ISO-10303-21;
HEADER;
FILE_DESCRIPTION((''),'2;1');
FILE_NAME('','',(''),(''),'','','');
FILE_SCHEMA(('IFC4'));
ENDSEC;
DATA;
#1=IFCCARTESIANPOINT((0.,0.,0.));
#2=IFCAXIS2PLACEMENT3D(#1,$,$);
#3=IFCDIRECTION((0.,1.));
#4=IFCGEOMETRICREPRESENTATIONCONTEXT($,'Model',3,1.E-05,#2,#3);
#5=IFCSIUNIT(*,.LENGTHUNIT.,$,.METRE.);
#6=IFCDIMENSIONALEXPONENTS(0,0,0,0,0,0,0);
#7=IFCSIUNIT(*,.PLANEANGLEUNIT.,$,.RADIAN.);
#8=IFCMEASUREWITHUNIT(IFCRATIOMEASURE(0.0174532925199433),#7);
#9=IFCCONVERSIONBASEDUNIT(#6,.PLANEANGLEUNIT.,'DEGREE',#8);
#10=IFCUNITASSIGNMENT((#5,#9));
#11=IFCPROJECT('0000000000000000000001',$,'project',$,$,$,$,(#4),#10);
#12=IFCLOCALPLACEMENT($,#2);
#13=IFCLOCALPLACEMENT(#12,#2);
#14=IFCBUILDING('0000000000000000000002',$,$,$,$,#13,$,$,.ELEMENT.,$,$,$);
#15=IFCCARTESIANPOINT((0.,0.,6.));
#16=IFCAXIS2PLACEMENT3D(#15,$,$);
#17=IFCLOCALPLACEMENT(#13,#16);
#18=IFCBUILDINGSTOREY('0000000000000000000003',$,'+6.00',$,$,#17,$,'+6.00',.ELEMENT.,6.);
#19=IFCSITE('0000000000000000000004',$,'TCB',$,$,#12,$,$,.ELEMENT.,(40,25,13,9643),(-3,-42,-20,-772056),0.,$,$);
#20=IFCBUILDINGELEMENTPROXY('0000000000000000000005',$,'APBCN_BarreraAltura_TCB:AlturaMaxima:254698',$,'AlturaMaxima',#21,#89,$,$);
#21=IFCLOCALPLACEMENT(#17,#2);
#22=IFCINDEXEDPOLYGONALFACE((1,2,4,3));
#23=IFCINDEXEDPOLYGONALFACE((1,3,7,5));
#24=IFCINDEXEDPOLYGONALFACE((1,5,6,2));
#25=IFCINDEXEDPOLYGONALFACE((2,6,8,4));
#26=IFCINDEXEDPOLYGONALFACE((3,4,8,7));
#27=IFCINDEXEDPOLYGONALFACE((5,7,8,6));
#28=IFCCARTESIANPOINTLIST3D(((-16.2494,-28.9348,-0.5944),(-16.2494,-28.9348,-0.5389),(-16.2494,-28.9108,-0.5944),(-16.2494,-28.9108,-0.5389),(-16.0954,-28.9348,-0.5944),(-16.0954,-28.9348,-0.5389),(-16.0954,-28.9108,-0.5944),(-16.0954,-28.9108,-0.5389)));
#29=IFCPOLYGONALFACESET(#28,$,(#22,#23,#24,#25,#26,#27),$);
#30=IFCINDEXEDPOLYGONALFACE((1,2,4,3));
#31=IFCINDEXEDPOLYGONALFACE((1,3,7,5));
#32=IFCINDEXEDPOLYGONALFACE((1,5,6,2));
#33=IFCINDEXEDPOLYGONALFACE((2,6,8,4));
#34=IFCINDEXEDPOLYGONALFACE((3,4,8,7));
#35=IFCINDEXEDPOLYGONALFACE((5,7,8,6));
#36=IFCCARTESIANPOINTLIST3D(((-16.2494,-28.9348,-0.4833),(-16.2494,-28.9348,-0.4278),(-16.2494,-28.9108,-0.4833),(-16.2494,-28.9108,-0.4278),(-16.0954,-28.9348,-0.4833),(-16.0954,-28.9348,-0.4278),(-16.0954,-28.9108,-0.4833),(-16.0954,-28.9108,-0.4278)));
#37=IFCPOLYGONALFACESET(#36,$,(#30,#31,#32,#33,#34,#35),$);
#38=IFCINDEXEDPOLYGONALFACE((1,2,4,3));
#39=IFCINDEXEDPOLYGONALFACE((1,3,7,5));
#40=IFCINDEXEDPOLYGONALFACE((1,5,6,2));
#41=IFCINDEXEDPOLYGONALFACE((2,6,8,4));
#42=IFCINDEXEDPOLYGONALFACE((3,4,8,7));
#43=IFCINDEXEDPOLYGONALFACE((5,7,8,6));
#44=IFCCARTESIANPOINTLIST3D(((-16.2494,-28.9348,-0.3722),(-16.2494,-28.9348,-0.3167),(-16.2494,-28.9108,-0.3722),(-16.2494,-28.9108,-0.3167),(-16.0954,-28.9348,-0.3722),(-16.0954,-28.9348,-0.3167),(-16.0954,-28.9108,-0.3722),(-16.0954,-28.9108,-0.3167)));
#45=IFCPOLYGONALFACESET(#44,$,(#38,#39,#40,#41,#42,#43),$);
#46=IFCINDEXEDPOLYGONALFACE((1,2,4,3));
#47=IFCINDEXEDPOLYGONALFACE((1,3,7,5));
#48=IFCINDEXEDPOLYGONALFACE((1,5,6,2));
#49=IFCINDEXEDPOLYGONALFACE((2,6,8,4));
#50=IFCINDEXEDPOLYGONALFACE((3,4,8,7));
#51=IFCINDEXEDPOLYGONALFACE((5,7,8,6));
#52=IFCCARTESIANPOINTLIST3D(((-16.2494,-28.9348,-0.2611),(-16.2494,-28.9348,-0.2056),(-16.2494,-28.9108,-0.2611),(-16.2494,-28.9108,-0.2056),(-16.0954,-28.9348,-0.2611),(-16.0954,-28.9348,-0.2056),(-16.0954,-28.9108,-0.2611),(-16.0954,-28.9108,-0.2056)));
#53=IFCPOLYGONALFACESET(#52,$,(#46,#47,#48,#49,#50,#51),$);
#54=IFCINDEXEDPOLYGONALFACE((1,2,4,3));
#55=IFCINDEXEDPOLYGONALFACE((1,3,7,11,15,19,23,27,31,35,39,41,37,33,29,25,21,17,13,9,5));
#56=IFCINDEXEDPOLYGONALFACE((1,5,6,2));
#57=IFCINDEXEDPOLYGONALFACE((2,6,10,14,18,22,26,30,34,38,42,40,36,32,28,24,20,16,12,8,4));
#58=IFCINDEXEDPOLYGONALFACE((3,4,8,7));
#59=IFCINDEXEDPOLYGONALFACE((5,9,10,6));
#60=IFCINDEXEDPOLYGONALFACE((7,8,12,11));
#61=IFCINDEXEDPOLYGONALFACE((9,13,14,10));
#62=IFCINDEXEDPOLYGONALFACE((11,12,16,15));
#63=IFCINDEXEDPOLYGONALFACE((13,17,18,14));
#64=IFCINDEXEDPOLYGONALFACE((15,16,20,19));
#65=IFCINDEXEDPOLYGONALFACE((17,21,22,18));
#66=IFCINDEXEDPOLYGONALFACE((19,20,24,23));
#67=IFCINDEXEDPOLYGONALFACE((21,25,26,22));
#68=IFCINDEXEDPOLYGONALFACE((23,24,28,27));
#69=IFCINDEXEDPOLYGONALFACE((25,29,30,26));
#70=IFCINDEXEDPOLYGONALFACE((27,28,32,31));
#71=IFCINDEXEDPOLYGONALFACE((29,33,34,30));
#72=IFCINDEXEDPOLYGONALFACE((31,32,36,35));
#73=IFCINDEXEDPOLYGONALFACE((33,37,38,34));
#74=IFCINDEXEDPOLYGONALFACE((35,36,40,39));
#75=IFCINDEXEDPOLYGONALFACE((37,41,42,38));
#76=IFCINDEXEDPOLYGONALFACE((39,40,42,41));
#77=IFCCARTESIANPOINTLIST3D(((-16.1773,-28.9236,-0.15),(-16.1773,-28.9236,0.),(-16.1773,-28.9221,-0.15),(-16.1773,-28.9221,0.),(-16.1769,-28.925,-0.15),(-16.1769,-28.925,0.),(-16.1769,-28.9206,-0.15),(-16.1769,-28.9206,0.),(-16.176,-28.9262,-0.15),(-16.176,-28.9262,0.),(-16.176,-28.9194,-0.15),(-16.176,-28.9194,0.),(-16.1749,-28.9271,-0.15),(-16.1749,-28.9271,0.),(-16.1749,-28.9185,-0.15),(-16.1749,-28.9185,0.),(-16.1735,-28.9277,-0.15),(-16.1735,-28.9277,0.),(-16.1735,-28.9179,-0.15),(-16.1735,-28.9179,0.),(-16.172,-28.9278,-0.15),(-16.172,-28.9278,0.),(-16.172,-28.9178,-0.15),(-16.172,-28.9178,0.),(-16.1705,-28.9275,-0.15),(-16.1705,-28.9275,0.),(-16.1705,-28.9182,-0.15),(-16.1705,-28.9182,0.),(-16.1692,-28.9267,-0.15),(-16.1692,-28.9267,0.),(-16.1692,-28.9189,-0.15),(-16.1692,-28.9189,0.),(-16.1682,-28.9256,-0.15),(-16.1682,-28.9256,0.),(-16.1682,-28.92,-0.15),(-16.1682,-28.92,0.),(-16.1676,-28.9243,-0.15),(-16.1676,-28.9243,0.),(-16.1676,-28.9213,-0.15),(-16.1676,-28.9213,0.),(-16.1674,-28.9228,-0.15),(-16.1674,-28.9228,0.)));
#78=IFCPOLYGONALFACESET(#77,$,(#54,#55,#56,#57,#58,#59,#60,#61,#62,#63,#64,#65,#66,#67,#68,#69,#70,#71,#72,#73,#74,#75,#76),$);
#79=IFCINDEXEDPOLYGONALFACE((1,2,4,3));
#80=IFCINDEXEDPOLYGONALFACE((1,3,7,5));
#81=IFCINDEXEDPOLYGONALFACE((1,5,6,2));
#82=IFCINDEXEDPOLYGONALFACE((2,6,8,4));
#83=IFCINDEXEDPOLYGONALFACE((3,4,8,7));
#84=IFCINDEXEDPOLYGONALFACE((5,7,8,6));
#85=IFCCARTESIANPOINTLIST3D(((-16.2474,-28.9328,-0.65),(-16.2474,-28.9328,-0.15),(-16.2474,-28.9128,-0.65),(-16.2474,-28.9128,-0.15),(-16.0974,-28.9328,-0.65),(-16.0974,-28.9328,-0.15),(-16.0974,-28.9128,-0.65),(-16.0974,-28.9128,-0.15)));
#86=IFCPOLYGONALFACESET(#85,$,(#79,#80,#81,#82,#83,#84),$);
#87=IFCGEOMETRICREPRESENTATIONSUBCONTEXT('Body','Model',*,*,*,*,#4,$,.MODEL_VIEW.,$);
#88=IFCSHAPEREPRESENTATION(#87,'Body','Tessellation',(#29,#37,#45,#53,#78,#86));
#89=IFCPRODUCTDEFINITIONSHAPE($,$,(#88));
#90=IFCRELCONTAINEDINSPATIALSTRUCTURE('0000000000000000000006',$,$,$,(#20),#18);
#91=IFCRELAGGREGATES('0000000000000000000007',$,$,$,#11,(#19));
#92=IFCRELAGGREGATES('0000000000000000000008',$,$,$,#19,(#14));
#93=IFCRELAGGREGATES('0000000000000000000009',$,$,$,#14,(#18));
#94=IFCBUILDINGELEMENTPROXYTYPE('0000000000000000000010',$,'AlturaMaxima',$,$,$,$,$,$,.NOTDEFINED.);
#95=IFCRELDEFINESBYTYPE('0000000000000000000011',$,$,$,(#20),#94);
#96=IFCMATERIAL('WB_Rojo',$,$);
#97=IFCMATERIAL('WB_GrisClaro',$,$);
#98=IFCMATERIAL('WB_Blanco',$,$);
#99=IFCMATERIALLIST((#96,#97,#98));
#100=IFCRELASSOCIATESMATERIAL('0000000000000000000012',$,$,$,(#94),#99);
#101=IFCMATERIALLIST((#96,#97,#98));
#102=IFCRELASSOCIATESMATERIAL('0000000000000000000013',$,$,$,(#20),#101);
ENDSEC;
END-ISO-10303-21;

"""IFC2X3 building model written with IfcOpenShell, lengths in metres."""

from ifc_helpers import new_model, entity, si_unit, converted_unit, direction, frame, frame_2d, origin, origin_2d_with_axis, place, context, subcontext, project, spatial, rectangle, circle, extrude, source, transform, mapped, material, material_list, type_object, type_shapes, element, save


model = new_model("IFC2X3")

# Units and contexts
model_context = context("Model", 3, precision=1e-05, world=origin(), true_north=direction((0.0, 1.0)))
body_context = subcontext(model_context, "Body", "Model", "MODEL_VIEW")
ifc_project = project(units=[si_unit("LENGTHUNIT", "METRE"), converted_unit("PLANEANGLEUNIT", "DEGREE", entity("IfcRatioMeasure", 0.0174532925199433), si_unit("PLANEANGLEUNIT", "RADIAN"), dimensions=[0, 0, 0, 0, 0, 0, 0])], contexts=[model_context])

# Site, building, storey
site_placement = place(None, origin())
site = spatial("IfcSite", under=ifc_project, at=site_placement, Name="TCB", CompositionType="ELEMENT", RefLatitude=(40, 25, 13, 9643), RefLongitude=(-3, -42, -20, -772056), RefElevation=0.0)
building_placement = place(site_placement, origin())
building = spatial("IfcBuilding", under=site, at=building_placement, CompositionType="ELEMENT")
storey_placement = place(building_placement, frame((0.0, 0.0, 6.0)))
storey = spatial("IfcBuildingStorey", under=building, at=storey_placement, Name="+6.00", LongName="+6.00", CompositionType="ELEMENT", Elevation=6.0)

# Building element proxy
ifc_material_1 = material(Name="WB_Rojo")
ifc_material_2 = material(Name="WB_GrisClaro")
ifc_material_3 = material(Name="WB_Blanco")
ifc_material_list_1 = material_list([ifc_material_1, ifc_material_2, ifc_material_3])
building_element_proxy_type = type_object("IfcBuildingElementProxyType", Name="AlturaMaxima", PredefinedType="NOTDEFINED", material=ifc_material_list_1)
shared_shape = source(origin(), body_context, "Body", "SweptSolid", [
    extrude(rectangle(XDim=0.154, YDim=0.024, at=frame_2d((0.0, 0.0), x_axis=(1.0, 0.0))), frame((0.0, 0.0, -0.5944), z_axis=(0.0, 0.0, 1.0), x_axis=(-1.0, 0.0, 0.0)), (0.0, 0.0, 1.0), 0.0556),
    extrude(rectangle(XDim=0.154, YDim=0.024, at=frame_2d((0.0, 0.0), x_axis=(1.0, 0.0))), frame((0.0, 0.0, -0.4833), z_axis=(0.0, 0.0, 1.0), x_axis=(-1.0, 0.0, 0.0)), (0.0, 0.0, 1.0), 0.0556),
    extrude(rectangle(XDim=0.154, YDim=0.024, at=frame_2d((0.0, 0.0), x_axis=(1.0, 0.0))), frame((0.0, 0.0, -0.3722), z_axis=(0.0, 0.0, 1.0), x_axis=(-1.0, 0.0, 0.0)), (0.0, 0.0, 1.0), 0.0556),
    extrude(rectangle(XDim=0.154, YDim=0.024, at=frame_2d((0.0, 0.0), x_axis=(1.0, 0.0))), frame((0.0, 0.0, -0.2611), z_axis=(0.0, 0.0, 1.0), x_axis=(-1.0, 0.0, 0.0)), (0.0, 0.0, 1.0), 0.0556),
    extrude(circle(Radius=0.005, at=frame_2d((0.0, 0.0), x_axis=(1.0, 0.0))), frame((0.0, 0.0, -0.15)), (0.0, 0.0, 1.0), 0.15),
    extrude(rectangle(XDim=0.02, YDim=0.15, at=origin_2d_with_axis()), frame((0.0, 0.0, -0.65), z_axis=(0.0, 0.0, 1.0), x_axis=(0.0, 1.0, 0.0)), (0.0, 0.0, 1.0), 0.5),
])
type_shapes(building_element_proxy_type, [shared_shape])
ifc_material_list_2 = material_list([ifc_material_1, ifc_material_2, ifc_material_3])
proxy_1_placement = place(storey_placement, frame((-16.1724, -28.9228, 0.0)))
element("IfcBuildingElementProxy", 1, at=proxy_1_placement, inside=storey, type_object=building_element_proxy_type, material=ifc_material_list_2, Name="APBCN_BarreraAltura_TCB:AlturaMaxima:254698", ObjectType="AlturaMaxima", context=body_context, shape_type="MappedRepresentation", body=[
    mapped(shared_shape, transform((0.0, 0.0, 0.0), scale=1.0)),
])

save(model, "model.ifc")
